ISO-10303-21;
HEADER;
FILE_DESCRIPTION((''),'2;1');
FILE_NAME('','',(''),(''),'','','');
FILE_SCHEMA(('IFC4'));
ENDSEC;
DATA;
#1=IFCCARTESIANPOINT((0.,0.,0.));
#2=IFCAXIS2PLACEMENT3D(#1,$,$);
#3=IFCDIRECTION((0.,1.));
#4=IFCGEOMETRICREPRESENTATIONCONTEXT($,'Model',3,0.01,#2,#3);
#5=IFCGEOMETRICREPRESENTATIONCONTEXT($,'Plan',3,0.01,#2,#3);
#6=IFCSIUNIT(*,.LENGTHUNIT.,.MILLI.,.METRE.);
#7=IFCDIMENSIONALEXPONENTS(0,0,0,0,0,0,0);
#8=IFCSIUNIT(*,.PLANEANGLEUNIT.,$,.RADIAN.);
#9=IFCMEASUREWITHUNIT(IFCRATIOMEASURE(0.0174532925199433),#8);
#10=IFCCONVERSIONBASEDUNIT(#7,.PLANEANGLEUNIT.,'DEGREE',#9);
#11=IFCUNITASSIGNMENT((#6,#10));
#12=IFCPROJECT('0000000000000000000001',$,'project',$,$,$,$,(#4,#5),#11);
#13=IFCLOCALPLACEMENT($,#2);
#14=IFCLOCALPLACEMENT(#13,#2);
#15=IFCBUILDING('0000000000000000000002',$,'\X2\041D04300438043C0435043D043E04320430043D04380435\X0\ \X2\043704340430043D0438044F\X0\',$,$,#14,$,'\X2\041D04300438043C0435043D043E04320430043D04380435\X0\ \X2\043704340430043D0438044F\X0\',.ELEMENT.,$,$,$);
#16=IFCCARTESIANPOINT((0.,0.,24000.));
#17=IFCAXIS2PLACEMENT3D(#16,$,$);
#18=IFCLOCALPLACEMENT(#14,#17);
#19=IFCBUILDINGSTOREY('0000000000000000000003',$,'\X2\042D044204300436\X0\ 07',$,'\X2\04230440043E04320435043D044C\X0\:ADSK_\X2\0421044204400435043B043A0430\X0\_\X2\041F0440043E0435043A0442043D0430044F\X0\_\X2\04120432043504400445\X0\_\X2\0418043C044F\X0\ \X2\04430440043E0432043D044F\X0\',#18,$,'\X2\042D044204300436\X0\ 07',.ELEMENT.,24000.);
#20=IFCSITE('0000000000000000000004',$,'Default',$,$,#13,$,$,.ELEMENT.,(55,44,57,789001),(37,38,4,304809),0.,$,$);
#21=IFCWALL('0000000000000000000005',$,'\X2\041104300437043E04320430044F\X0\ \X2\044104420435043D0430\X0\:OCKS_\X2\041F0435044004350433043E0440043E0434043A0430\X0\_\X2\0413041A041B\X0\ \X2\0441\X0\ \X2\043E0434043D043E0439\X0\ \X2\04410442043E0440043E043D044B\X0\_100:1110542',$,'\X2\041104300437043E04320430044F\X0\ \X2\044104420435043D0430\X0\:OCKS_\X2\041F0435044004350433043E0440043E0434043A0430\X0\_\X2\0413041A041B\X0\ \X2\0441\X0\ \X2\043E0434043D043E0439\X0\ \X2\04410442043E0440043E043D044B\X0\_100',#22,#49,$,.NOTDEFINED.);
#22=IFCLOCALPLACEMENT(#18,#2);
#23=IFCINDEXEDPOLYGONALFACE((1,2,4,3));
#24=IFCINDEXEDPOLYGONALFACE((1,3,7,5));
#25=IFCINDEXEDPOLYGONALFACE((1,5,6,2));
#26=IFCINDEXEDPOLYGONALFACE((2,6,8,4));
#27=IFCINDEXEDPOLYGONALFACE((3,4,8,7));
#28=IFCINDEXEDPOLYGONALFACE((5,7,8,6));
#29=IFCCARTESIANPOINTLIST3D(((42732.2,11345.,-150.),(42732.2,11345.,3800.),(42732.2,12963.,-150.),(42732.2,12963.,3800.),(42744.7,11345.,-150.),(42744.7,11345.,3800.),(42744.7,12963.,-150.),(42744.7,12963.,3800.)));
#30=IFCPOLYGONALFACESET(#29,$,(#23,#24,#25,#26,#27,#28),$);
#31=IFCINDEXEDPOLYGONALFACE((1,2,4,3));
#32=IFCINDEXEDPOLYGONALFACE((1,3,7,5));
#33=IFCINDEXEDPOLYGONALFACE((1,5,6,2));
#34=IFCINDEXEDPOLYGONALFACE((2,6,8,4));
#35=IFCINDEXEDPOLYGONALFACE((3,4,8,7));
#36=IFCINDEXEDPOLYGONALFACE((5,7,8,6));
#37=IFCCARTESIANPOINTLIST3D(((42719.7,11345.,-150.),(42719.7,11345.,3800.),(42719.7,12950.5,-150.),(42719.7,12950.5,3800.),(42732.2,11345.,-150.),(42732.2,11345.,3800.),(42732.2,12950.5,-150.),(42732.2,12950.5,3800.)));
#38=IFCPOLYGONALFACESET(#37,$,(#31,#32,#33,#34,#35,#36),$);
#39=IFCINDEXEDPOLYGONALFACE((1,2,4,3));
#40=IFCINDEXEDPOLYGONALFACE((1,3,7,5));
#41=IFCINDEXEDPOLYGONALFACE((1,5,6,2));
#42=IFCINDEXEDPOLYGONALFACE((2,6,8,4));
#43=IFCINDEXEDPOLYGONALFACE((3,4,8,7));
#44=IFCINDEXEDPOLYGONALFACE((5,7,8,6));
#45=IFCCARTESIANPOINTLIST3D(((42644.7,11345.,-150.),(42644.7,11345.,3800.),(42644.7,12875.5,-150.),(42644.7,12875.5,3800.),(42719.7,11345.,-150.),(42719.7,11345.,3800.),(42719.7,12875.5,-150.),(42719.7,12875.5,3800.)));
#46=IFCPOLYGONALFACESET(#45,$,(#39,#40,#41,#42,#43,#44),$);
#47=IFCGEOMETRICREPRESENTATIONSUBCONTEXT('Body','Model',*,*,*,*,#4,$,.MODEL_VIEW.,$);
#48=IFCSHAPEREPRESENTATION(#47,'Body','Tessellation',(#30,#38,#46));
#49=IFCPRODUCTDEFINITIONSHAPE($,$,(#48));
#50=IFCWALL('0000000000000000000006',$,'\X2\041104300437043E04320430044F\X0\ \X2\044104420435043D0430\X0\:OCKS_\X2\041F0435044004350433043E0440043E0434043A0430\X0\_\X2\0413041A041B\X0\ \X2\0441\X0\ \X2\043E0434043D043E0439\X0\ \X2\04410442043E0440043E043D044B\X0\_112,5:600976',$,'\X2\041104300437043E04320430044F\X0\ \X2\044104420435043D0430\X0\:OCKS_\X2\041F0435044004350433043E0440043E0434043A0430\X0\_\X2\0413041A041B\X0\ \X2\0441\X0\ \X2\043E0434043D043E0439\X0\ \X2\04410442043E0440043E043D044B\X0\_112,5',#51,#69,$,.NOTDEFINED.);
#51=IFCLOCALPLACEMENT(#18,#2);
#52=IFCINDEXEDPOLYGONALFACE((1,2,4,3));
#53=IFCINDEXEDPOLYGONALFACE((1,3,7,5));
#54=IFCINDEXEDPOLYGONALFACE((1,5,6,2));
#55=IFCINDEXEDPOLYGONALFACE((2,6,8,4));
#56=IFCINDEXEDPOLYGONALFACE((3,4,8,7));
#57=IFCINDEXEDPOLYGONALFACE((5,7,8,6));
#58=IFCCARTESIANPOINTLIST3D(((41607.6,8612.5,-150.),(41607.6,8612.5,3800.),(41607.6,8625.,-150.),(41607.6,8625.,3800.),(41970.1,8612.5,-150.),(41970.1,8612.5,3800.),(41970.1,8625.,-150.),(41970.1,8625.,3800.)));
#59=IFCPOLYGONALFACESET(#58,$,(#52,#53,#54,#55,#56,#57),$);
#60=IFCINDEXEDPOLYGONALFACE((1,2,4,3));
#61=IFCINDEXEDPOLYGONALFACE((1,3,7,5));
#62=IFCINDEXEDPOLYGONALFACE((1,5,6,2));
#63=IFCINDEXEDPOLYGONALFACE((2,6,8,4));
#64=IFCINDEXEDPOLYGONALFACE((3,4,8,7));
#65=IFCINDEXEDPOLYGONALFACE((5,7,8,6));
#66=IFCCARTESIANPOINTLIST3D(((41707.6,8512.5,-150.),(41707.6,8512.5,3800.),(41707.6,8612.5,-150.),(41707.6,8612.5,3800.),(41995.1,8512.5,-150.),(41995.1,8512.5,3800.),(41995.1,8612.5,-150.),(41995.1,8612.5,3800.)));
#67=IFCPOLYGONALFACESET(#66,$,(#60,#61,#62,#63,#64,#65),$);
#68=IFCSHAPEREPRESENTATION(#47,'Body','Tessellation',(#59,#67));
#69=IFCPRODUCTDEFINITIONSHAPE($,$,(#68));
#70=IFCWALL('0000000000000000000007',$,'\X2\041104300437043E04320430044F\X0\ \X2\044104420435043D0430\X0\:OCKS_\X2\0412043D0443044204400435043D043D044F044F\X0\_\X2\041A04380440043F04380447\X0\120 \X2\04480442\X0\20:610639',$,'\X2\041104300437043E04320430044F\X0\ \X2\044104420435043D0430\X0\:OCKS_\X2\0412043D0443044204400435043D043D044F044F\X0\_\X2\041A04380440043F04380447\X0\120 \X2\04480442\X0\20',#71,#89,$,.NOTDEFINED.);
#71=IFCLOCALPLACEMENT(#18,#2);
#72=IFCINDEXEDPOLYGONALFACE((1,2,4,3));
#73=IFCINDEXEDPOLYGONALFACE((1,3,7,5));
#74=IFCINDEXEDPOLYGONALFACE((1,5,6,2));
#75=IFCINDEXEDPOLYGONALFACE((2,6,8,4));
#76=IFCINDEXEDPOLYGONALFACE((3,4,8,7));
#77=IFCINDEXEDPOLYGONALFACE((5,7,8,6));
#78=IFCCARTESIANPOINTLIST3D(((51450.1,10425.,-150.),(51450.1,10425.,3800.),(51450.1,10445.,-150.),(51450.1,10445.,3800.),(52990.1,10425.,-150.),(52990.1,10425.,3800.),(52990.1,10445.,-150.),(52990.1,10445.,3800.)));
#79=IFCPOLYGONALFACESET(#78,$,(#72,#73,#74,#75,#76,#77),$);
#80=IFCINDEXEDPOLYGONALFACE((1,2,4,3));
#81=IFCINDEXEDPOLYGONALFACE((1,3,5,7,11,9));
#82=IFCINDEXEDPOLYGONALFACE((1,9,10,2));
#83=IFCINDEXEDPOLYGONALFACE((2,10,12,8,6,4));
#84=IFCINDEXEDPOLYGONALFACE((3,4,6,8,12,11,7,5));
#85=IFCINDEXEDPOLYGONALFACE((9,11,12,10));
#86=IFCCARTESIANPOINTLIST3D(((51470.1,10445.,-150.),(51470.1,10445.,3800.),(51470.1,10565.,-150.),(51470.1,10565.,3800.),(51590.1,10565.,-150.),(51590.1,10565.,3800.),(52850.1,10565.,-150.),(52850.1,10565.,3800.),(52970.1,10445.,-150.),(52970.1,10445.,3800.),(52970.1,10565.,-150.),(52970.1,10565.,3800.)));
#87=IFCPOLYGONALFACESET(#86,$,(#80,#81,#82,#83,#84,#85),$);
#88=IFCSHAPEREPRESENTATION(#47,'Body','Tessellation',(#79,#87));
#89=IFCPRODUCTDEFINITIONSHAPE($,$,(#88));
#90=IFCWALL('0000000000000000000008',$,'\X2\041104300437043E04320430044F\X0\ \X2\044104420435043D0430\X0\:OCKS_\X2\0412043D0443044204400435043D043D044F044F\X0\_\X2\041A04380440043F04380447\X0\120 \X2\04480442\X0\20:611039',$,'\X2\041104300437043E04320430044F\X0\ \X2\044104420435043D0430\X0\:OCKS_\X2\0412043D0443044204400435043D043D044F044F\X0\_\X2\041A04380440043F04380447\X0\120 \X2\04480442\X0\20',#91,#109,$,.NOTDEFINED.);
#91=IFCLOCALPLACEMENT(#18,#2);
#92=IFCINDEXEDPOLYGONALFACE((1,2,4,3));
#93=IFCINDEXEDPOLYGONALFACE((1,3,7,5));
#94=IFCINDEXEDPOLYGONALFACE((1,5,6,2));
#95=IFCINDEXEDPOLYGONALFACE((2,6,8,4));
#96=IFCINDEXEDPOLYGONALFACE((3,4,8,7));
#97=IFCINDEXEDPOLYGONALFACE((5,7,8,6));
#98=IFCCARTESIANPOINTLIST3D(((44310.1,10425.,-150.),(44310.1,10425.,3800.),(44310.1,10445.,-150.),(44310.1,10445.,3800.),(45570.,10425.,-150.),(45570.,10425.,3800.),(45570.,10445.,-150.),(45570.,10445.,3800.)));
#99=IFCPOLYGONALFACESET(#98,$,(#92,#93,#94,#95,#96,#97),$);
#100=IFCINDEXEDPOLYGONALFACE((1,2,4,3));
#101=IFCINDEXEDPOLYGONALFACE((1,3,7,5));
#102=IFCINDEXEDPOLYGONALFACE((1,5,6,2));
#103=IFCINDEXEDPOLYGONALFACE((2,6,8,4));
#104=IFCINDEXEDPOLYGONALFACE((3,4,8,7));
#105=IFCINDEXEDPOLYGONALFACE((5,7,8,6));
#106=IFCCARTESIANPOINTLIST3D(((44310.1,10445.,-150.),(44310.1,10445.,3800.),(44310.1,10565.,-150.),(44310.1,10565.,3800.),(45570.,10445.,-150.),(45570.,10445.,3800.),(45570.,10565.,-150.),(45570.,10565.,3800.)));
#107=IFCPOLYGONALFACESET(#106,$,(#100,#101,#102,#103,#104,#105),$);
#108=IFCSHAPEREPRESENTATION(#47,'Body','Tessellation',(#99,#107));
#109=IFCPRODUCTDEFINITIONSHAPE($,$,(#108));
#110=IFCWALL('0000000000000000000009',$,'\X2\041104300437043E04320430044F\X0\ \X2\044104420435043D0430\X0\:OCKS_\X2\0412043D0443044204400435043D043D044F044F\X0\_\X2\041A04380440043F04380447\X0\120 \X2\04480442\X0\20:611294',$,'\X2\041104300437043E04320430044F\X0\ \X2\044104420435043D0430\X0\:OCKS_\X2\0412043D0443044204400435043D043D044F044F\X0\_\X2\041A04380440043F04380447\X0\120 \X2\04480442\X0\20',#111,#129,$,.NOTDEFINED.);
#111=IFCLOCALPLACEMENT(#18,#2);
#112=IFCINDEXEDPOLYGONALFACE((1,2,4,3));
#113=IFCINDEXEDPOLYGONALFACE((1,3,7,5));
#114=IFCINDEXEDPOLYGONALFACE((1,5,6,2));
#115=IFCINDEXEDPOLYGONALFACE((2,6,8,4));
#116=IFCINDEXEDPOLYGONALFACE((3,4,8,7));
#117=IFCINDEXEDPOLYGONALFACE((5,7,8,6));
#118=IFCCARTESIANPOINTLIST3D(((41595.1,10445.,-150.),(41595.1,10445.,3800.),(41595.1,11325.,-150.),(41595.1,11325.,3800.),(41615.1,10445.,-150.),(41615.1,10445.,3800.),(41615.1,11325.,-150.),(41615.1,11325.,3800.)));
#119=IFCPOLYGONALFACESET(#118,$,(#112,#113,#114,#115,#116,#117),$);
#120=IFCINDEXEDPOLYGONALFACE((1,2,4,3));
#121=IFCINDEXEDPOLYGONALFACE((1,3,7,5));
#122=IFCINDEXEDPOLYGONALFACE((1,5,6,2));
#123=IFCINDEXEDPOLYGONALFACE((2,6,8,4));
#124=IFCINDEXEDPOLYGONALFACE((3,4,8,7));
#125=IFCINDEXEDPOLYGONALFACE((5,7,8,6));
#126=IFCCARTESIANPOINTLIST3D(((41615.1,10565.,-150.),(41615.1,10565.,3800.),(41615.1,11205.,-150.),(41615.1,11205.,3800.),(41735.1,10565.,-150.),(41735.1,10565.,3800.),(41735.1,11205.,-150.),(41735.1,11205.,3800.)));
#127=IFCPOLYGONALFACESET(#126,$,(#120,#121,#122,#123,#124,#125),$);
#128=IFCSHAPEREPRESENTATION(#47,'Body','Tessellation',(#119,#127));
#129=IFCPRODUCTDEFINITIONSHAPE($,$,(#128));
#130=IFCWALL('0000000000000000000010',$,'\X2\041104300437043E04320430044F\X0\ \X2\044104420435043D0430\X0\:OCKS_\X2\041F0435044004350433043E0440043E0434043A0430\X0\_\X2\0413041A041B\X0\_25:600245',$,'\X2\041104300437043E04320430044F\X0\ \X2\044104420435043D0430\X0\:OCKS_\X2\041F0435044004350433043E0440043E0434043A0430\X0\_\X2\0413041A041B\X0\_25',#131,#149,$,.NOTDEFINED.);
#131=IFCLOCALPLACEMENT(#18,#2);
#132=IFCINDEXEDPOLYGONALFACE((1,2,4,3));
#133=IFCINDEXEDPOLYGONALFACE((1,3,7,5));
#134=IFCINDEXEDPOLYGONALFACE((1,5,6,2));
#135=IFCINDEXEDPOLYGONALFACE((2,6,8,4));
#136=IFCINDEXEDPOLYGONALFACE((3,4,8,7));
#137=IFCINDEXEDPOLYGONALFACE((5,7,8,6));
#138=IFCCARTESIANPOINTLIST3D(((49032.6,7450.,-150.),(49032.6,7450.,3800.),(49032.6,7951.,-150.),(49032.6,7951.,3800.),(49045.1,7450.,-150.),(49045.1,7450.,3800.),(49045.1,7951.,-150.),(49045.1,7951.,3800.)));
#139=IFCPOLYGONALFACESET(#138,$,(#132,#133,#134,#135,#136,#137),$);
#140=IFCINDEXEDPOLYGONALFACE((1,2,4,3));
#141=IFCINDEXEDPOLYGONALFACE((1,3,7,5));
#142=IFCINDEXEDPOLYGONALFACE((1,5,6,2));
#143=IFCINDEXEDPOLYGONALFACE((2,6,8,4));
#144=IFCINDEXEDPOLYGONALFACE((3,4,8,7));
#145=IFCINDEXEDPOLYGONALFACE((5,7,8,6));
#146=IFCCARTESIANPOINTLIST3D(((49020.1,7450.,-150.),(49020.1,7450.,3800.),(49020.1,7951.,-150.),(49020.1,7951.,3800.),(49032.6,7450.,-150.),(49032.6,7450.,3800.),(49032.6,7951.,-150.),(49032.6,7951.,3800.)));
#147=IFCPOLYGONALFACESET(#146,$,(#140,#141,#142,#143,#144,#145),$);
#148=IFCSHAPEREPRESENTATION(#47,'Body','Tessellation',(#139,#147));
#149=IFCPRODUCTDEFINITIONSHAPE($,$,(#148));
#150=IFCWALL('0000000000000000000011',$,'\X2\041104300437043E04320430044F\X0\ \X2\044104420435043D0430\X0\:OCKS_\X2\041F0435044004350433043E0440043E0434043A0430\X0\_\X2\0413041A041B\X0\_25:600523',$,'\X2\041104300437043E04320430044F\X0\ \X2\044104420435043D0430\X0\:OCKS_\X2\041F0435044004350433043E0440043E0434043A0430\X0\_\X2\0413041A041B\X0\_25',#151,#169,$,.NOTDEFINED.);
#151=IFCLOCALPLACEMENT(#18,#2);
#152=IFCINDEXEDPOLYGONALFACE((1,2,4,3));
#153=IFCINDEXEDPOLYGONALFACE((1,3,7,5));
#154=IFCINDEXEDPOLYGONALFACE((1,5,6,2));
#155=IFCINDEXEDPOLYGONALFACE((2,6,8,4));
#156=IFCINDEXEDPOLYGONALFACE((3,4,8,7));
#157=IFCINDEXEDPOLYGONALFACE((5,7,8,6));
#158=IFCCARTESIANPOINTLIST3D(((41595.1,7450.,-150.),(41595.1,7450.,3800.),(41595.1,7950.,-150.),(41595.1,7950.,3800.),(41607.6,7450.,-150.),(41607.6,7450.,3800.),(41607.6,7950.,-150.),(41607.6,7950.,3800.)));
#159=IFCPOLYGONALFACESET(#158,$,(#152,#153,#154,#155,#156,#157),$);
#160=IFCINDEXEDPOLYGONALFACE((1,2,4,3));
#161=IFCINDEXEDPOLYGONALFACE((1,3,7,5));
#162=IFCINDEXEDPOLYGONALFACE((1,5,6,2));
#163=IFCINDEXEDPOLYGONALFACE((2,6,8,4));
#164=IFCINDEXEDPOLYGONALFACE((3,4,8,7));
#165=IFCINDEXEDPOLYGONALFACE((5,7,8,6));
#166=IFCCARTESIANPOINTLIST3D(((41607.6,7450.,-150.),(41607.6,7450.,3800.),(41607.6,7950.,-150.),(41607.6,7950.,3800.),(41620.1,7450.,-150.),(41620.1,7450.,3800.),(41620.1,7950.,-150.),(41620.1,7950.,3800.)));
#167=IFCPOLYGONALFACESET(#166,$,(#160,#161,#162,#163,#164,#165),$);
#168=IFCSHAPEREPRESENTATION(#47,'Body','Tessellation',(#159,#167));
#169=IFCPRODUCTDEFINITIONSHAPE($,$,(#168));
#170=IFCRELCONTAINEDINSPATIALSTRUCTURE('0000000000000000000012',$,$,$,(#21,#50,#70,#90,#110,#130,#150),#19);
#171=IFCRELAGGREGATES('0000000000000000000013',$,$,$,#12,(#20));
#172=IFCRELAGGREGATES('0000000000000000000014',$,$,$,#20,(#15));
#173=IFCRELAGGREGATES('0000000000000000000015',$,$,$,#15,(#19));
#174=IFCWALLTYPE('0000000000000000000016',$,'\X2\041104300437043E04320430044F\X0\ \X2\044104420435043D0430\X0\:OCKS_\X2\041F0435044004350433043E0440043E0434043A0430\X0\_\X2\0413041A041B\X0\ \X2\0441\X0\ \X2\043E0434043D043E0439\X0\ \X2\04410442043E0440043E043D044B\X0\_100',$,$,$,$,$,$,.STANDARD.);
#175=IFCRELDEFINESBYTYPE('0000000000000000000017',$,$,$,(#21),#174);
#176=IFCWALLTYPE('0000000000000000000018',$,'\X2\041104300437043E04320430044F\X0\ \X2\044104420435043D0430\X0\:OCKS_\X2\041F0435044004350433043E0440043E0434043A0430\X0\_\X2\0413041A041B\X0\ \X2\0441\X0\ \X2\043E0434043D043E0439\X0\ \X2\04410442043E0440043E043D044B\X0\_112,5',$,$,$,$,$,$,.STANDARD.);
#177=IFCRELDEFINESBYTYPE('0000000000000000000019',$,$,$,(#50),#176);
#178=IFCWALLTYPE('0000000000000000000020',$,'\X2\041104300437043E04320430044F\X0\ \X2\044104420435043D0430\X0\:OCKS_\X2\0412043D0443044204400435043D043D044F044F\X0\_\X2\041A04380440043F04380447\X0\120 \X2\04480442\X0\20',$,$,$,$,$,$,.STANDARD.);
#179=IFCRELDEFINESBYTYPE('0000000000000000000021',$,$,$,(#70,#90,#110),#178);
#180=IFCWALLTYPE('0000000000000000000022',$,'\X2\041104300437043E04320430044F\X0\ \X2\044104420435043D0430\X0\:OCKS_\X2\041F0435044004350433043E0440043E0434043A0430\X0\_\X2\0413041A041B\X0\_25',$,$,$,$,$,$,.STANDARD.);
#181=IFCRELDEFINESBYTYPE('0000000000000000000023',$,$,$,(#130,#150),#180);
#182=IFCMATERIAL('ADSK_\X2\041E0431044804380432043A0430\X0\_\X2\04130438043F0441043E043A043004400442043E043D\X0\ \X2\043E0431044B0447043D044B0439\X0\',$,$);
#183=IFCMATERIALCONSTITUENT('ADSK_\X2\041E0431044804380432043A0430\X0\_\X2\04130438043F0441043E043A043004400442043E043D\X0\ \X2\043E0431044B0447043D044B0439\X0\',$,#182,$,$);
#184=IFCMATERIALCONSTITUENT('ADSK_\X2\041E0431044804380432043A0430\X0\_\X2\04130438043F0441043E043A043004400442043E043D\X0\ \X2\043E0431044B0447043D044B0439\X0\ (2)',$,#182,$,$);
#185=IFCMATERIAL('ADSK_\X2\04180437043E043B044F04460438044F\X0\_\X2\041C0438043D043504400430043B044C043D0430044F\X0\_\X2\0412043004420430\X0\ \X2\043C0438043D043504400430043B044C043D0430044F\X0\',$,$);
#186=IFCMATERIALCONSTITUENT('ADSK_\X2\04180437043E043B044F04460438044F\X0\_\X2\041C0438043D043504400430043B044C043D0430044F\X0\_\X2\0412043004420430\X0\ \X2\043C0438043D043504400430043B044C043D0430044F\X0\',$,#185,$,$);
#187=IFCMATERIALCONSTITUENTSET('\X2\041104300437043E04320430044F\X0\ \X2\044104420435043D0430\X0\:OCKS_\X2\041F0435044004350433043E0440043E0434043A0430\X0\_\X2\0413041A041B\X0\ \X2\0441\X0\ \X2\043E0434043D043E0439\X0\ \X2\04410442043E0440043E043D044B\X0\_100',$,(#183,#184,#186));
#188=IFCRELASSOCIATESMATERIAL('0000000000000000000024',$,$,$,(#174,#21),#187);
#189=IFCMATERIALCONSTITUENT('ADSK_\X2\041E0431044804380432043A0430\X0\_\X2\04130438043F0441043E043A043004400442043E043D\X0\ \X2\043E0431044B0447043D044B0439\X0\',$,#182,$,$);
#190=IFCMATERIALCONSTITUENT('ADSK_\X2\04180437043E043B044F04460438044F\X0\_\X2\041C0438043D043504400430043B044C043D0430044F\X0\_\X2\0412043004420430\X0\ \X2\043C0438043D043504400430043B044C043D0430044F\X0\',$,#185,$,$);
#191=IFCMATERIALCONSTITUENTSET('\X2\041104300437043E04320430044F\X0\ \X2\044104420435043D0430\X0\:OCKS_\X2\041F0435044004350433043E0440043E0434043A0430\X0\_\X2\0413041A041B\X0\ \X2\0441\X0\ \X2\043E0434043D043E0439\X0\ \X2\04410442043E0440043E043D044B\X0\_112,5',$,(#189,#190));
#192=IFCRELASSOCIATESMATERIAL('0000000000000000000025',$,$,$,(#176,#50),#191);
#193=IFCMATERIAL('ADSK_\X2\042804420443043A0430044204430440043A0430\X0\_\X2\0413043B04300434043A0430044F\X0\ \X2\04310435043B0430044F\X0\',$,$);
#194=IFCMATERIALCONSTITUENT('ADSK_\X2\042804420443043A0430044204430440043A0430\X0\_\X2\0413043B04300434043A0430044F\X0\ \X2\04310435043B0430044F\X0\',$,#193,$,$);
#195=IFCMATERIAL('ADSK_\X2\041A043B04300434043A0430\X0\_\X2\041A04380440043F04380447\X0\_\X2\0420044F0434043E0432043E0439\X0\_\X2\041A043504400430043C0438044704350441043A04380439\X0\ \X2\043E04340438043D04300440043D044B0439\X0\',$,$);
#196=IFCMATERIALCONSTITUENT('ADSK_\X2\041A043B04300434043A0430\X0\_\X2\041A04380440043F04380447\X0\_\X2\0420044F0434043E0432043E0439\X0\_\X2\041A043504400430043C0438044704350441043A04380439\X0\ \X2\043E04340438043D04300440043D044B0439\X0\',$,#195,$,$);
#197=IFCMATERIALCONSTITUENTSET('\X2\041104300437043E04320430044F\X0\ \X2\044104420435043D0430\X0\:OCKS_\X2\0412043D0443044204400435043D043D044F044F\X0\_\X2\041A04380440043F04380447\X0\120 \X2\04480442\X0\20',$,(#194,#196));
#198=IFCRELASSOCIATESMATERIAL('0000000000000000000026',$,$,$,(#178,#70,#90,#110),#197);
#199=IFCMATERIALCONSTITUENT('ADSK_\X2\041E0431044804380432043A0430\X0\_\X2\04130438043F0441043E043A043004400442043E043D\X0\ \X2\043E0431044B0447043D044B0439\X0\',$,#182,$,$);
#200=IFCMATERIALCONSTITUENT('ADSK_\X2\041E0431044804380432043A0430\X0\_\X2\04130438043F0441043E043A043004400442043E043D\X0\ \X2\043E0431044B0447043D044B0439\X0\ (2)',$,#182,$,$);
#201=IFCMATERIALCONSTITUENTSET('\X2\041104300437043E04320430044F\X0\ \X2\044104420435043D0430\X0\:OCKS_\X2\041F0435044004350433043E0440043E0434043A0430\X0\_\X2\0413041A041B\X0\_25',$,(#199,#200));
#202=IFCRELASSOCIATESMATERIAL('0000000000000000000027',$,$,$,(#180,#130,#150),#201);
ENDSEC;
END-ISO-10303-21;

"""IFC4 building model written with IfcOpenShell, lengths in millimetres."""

from ifc_helpers import new_model, entity, si_unit, converted_unit, direction, frame, origin, place, context, subcontext, project, spatial, indexed_curve, outline, extrude, material, constituent, constituent_set, type_object, element, save


model = new_model("IFC4")

# Units and contexts
model_context = context("Model", 3, precision=0.01, world=origin(), true_north=direction((0.0, 1.0)))
plan_context = context("Plan", 3, precision=0.01, world=origin(), true_north=direction((0.0, 1.0)))
body_context = subcontext(model_context, "Body", "Model", "MODEL_VIEW")
ifc_project = project(units=[si_unit("LENGTHUNIT", "METRE", prefix="MILLI"), converted_unit("PLANEANGLEUNIT", "DEGREE", entity("IfcRatioMeasure", 0.0174532925199433), si_unit("PLANEANGLEUNIT", "RADIAN"), dimensions=[0, 0, 0, 0, 0, 0, 0])], contexts=[model_context, plan_context])

# Site, building, storey
site_placement = place(None, frame((0.0, 0.0, 0.0)))
site = spatial("IfcSite", under=ifc_project, at=site_placement, Name="Default", CompositionType="ELEMENT", RefLatitude=(55, 44, 57, 789001), RefLongitude=(37, 38, 4, 304809), RefElevation=0.0)
building_placement = place(site_placement, origin())
building = spatial("IfcBuilding", under=site, at=building_placement, Name="Наименование здания", LongName="Наименование здания", CompositionType="ELEMENT")
storey_placement = place(building_placement, frame((0.0, 0.0, 24000.0)))
storey = spatial("IfcBuildingStorey", under=building, at=storey_placement, Name="Этаж 07", ObjectType="Уровень:ADSK_Стрелка_Проектная_Вверх_Имя уровня", LongName="Этаж 07", CompositionType="ELEMENT", Elevation=24000.0)

# Shared definitions
ifc_material_1 = material(Name="ADSK_Обшивка_Гипсокартон обычный")
ifc_material_2 = material(Name="ADSK_Изоляция_Минеральная_Вата минеральная")

# Walls
ifc_constituent_1 = constituent(ifc_material_1, Name="ADSK_Обшивка_Гипсокартон обычный")
ifc_constituent_2 = constituent(ifc_material_1, Name="ADSK_Обшивка_Гипсокартон обычный (2)")
ifc_constituent_3 = constituent(ifc_material_2, Name="ADSK_Изоляция_Минеральная_Вата минеральная")
ifc_constituent_set_1 = constituent_set(constituents=[ifc_constituent_1, ifc_constituent_2, ifc_constituent_3], Name="Базовая стена:OCKS_Перегородка_ГКЛ с одной стороны_100")
wall_type_1 = type_object("IfcWallType", Name="Базовая стена:OCKS_Перегородка_ГКЛ с одной стороны_100", PredefinedType="STANDARD", material=ifc_constituent_set_1)
wall_1_placement = place(storey_placement, frame((42694.7, 12875.5, -150.0), z_axis=(0.0, 0.0, 1.0), x_axis=(0.0, -1.0, 0.0)))
element("IfcWall", 1, at=wall_1_placement, inside=storey, type_object=wall_type_1, material=ifc_constituent_set_1, Name="Базовая стена:OCKS_Перегородка_ГКЛ с одной стороны_100:1110542", ObjectType="Базовая стена:OCKS_Перегородка_ГКЛ с одной стороны_100", PredefinedType="NOTDEFINED", context=body_context, shape_type="SweptSolid", body=[
    extrude(outline(indexed_curve([(-6.2, -809.0), (6.3, -809.0), (6.3, 809.0), (-6.2, 809.0), (-6.2, -809.0)], self_intersect=False)), frame((721.5, 43.8, 0.0), z_axis=(0.0, 0.0, 1.0), x_axis=(0.0, -1.0, 0.0)), (0.0, 0.0, 1.0), 3950.0),
    extrude(outline(indexed_curve([(-802.8, -6.2), (802.8, -6.2), (802.8, 6.3), (-802.8, 6.3), (-802.8, -6.2)], self_intersect=False)), frame((727.8, 31.2, 0.0)), (0.0, 0.0, 1.0), 3950.0),
    extrude(outline(indexed_curve([(-37.5, -765.3), (37.5, -765.3), (37.5, 765.3), (-37.5, 765.3), (-37.5, -765.3)], self_intersect=False)), frame((765.3, -12.5, 0.0), z_axis=(0.0, 0.0, 1.0), x_axis=(0.0, 1.0, 0.0)), (0.0, 0.0, 1.0), 3950.0),
])
ifc_constituent_4 = constituent(ifc_material_1, Name="ADSK_Обшивка_Гипсокартон обычный")
ifc_constituent_5 = constituent(ifc_material_2, Name="ADSK_Изоляция_Минеральная_Вата минеральная")
ifc_constituent_set_2 = constituent_set(constituents=[ifc_constituent_4, ifc_constituent_5], Name="Базовая стена:OCKS_Перегородка_ГКЛ с одной стороны_112,5")
wall_type_2 = type_object("IfcWallType", Name="Базовая стена:OCKS_Перегородка_ГКЛ с одной стороны_112,5", PredefinedType="STANDARD", material=ifc_constituent_set_2)
wall_2_placement = place(storey_placement, frame((41707.6, 8568.7, -150.0)))
element("IfcWall", 2, at=wall_2_placement, inside=storey, type_object=wall_type_2, material=ifc_constituent_set_2, Name="Базовая стена:OCKS_Перегородка_ГКЛ с одной стороны_112,5:600976", ObjectType="Базовая стена:OCKS_Перегородка_ГКЛ с одной стороны_112,5", PredefinedType="NOTDEFINED", context=body_context, shape_type="SweptSolid", body=[
    extrude(outline(indexed_curve([(-6.3, -181.3), (6.2, -181.3), (6.3, 181.3), (-6.2, 181.3), (-6.3, -181.3)], self_intersect=False)), frame((81.3, 50.0, 0.0), z_axis=(0.0, 0.0, 1.0), x_axis=(0.0, -1.0, 0.0)), (0.0, 0.0, 1.0), 3950.0),
    extrude(outline(indexed_curve([(-50.0, -143.8), (50.0, -143.8), (50.0, 143.8), (-50.0, 143.8), (-50.0, -143.8)], self_intersect=False)), frame((143.8, -6.3, 0.0), z_axis=(0.0, 0.0, 1.0), x_axis=(0.0, 1.0, 0.0)), (0.0, 0.0, 1.0), 3950.0),
])
ifc_material_3 = material(Name="ADSK_Штукатурка_Гладкая белая")
ifc_constituent_6 = constituent(ifc_material_3, Name="ADSK_Штукатурка_Гладкая белая")
ifc_material_4 = material(Name="ADSK_Кладка_Кирпич_Рядовой_Керамический одинарный")
ifc_constituent_7 = constituent(ifc_material_4, Name="ADSK_Кладка_Кирпич_Рядовой_Керамический одинарный")
ifc_constituent_set_3 = constituent_set(constituents=[ifc_constituent_6, ifc_constituent_7], Name="Базовая стена:OCKS_Внутренняя_Кирпич120 шт20")
wall_type_3 = type_object("IfcWallType", Name="Базовая стена:OCKS_Внутренняя_Кирпич120 шт20", PredefinedType="STANDARD", material=ifc_constituent_set_3)
wall_3_placement = place(storey_placement, frame((51450.1, 10495.0, -150.0)))
element("IfcWall", 3, at=wall_3_placement, inside=storey, type_object=wall_type_3, material=ifc_constituent_set_3, Name="Базовая стена:OCKS_Внутренняя_Кирпич120 шт20:610639", ObjectType="Базовая стена:OCKS_Внутренняя_Кирпич120 шт20", PredefinedType="NOTDEFINED", context=body_context, shape_type="SweptSolid", body=[
    extrude(outline(indexed_curve([(-10.0, -770.0), (10.0, -770.0), (10.0, 770.0), (-10.0, 770.0), (-10.0, -770.0)], self_intersect=False)), frame((770.0, -60.0, 0.0), z_axis=(0.0, 0.0, 1.0), x_axis=(0.0, 1.0, 0.0)), (0.0, 0.0, 1.0), 3950.0),
    extrude(outline(indexed_curve([(-630.0, -40.0), (630.0, -40.0), (750.0, -40.0), (750.0, 80.0), (-750.0, 80.0), (-750.0, -40.0), (-630.0, -40.0)], self_intersect=False)), frame((770.0, 30.0, 0.0), z_axis=(0.0, 0.0, 1.0), x_axis=(-1.0, 0.0, 0.0)), (0.0, 0.0, 1.0), 3950.0),
])
wall_4_placement = place(storey_placement, frame((45570.0, 10495.0, -150.0), z_axis=(0.0, 0.0, 1.0), x_axis=(-1.0, 0.0, 0.0)))
element("IfcWall", 4, at=wall_4_placement, inside=storey, type_object=wall_type_3, material=ifc_constituent_set_3, Name="Базовая стена:OCKS_Внутренняя_Кирпич120 шт20:611039", ObjectType="Базовая стена:OCKS_Внутренняя_Кирпич120 шт20", PredefinedType="NOTDEFINED", context=body_context, shape_type="SweptSolid", body=[
    extrude(outline(indexed_curve([(-10.0, -629.9), (10.0, -629.9), (10.0, 629.9), (-10.0, 629.9), (-10.0, -629.9)], self_intersect=False)), frame((629.9, 60.0, 0.0), z_axis=(0.0, 0.0, 1.0), x_axis=(0.0, -1.0, 0.0)), (0.0, 0.0, 1.0), 3950.0),
    extrude(outline(indexed_curve([(-60.0, -629.9), (60.0, -629.9), (60.0, 629.9), (-60.0, 629.9), (-60.0, -629.9)], self_intersect=False)), frame((629.9, -10.0, 0.0), z_axis=(0.0, 0.0, 1.0), x_axis=(0.0, 1.0, 0.0)), (0.0, 0.0, 1.0), 3950.0),
])
wall_5_placement = place(storey_placement, frame((41665.1, 10565.0, -150.0), z_axis=(0.0, 0.0, 1.0), x_axis=(0.0, 1.0, 0.0)))
element("IfcWall", 5, at=wall_5_placement, inside=storey, type_object=wall_type_3, material=ifc_constituent_set_3, Name="Базовая стена:OCKS_Внутренняя_Кирпич120 шт20:611294", ObjectType="Базовая стена:OCKS_Внутренняя_Кирпич120 шт20", PredefinedType="NOTDEFINED", context=body_context, shape_type="SweptSolid", body=[
    extrude(outline(indexed_curve([(-10.0, -440.0), (10.0, -440.0), (10.0, 440.0), (-10.0, 440.0), (-10.0, -440.0)], self_intersect=False)), frame((320.0, 60.0, 0.0), z_axis=(0.0, 0.0, 1.0), x_axis=(0.0, -1.0, 0.0)), (0.0, 0.0, 1.0), 3950.0),
    extrude(outline(indexed_curve([(-60.0, -320.0), (60.0, -320.0), (60.0, 320.0), (-60.0, 320.0), (-60.0, -320.0)], self_intersect=False)), frame((320.0, -10.0, 0.0), z_axis=(0.0, 0.0, 1.0), x_axis=(0.0, 1.0, 0.0)), (0.0, 0.0, 1.0), 3950.0),
])
ifc_constituent_8 = constituent(ifc_material_1, Name="ADSK_Обшивка_Гипсокартон обычный")
ifc_constituent_9 = constituent(ifc_material_1, Name="ADSK_Обшивка_Гипсокартон обычный (2)")
ifc_constituent_set_4 = constituent_set(constituents=[ifc_constituent_8, ifc_constituent_9], Name="Базовая стена:OCKS_Перегородка_ГКЛ_25")
wall_type_4 = type_object("IfcWallType", Name="Базовая стена:OCKS_Перегородка_ГКЛ_25", PredefinedType="STANDARD", material=ifc_constituent_set_4)
wall_6_placement = place(storey_placement, frame((49032.6, 7450.0, -150.0), z_axis=(0.0, 0.0, 1.0), x_axis=(0.0, 1.0, 0.0)))
element("IfcWall", 6, at=wall_6_placement, inside=storey, type_object=wall_type_4, material=ifc_constituent_set_4, Name="Базовая стена:OCKS_Перегородка_ГКЛ_25:600245", ObjectType="Базовая стена:OCKS_Перегородка_ГКЛ_25", PredefinedType="NOTDEFINED", context=body_context, shape_type="SweptSolid", body=[
    extrude(outline(indexed_curve([(-6.3, -250.5), (6.2, -250.5), (6.3, 250.5), (-6.2, 250.5), (-6.3, -250.5)], self_intersect=False)), frame((250.5, -6.3, 0.0), z_axis=(0.0, 0.0, 1.0), x_axis=(0.0, 1.0, 0.0)), (0.0, 0.0, 1.0), 3950.0),
    extrude(outline(indexed_curve([(-6.3, -250.5), (6.2, -250.5), (6.2, 250.5), (-6.3, 250.5), (-6.3, -250.5)], self_intersect=False)), frame((250.5, 6.2, 0.0), z_axis=(0.0, 0.0, 1.0), x_axis=(0.0, -1.0, 0.0)), (0.0, 0.0, 1.0), 3950.0),
])
wall_7_placement = place(storey_placement, frame((41607.6, 7450.0, -150.0), z_axis=(0.0, 0.0, 1.0), x_axis=(0.0, 1.0, 0.0)))
element("IfcWall", 7, at=wall_7_placement, inside=storey, type_object=wall_type_4, material=ifc_constituent_set_4, Name="Базовая стена:OCKS_Перегородка_ГКЛ_25:600523", ObjectType="Базовая стена:OCKS_Перегородка_ГКЛ_25", PredefinedType="NOTDEFINED", context=body_context, shape_type="SweptSolid", body=[
    extrude(outline(indexed_curve([(-6.2, -250.0), (6.3, -250.0), (6.3, 250.0), (-6.2, 250.0), (-6.2, -250.0)], self_intersect=False)), frame((250.0, 6.3, 0.0), z_axis=(0.0, 0.0, 1.0), x_axis=(0.0, -1.0, 0.0)), (0.0, 0.0, 1.0), 3950.0),
    extrude(outline(indexed_curve([(-6.3, -250.0), (6.2, -250.0), (6.3, 250.0), (-6.2, 250.0), (-6.3, -250.0)], self_intersect=False)), frame((250.0, -6.3, 0.0), z_axis=(0.0, 0.0, 1.0), x_axis=(0.0, 1.0, 0.0)), (0.0, 0.0, 1.0), 3950.0),
])

save(model, "model.ifc")
